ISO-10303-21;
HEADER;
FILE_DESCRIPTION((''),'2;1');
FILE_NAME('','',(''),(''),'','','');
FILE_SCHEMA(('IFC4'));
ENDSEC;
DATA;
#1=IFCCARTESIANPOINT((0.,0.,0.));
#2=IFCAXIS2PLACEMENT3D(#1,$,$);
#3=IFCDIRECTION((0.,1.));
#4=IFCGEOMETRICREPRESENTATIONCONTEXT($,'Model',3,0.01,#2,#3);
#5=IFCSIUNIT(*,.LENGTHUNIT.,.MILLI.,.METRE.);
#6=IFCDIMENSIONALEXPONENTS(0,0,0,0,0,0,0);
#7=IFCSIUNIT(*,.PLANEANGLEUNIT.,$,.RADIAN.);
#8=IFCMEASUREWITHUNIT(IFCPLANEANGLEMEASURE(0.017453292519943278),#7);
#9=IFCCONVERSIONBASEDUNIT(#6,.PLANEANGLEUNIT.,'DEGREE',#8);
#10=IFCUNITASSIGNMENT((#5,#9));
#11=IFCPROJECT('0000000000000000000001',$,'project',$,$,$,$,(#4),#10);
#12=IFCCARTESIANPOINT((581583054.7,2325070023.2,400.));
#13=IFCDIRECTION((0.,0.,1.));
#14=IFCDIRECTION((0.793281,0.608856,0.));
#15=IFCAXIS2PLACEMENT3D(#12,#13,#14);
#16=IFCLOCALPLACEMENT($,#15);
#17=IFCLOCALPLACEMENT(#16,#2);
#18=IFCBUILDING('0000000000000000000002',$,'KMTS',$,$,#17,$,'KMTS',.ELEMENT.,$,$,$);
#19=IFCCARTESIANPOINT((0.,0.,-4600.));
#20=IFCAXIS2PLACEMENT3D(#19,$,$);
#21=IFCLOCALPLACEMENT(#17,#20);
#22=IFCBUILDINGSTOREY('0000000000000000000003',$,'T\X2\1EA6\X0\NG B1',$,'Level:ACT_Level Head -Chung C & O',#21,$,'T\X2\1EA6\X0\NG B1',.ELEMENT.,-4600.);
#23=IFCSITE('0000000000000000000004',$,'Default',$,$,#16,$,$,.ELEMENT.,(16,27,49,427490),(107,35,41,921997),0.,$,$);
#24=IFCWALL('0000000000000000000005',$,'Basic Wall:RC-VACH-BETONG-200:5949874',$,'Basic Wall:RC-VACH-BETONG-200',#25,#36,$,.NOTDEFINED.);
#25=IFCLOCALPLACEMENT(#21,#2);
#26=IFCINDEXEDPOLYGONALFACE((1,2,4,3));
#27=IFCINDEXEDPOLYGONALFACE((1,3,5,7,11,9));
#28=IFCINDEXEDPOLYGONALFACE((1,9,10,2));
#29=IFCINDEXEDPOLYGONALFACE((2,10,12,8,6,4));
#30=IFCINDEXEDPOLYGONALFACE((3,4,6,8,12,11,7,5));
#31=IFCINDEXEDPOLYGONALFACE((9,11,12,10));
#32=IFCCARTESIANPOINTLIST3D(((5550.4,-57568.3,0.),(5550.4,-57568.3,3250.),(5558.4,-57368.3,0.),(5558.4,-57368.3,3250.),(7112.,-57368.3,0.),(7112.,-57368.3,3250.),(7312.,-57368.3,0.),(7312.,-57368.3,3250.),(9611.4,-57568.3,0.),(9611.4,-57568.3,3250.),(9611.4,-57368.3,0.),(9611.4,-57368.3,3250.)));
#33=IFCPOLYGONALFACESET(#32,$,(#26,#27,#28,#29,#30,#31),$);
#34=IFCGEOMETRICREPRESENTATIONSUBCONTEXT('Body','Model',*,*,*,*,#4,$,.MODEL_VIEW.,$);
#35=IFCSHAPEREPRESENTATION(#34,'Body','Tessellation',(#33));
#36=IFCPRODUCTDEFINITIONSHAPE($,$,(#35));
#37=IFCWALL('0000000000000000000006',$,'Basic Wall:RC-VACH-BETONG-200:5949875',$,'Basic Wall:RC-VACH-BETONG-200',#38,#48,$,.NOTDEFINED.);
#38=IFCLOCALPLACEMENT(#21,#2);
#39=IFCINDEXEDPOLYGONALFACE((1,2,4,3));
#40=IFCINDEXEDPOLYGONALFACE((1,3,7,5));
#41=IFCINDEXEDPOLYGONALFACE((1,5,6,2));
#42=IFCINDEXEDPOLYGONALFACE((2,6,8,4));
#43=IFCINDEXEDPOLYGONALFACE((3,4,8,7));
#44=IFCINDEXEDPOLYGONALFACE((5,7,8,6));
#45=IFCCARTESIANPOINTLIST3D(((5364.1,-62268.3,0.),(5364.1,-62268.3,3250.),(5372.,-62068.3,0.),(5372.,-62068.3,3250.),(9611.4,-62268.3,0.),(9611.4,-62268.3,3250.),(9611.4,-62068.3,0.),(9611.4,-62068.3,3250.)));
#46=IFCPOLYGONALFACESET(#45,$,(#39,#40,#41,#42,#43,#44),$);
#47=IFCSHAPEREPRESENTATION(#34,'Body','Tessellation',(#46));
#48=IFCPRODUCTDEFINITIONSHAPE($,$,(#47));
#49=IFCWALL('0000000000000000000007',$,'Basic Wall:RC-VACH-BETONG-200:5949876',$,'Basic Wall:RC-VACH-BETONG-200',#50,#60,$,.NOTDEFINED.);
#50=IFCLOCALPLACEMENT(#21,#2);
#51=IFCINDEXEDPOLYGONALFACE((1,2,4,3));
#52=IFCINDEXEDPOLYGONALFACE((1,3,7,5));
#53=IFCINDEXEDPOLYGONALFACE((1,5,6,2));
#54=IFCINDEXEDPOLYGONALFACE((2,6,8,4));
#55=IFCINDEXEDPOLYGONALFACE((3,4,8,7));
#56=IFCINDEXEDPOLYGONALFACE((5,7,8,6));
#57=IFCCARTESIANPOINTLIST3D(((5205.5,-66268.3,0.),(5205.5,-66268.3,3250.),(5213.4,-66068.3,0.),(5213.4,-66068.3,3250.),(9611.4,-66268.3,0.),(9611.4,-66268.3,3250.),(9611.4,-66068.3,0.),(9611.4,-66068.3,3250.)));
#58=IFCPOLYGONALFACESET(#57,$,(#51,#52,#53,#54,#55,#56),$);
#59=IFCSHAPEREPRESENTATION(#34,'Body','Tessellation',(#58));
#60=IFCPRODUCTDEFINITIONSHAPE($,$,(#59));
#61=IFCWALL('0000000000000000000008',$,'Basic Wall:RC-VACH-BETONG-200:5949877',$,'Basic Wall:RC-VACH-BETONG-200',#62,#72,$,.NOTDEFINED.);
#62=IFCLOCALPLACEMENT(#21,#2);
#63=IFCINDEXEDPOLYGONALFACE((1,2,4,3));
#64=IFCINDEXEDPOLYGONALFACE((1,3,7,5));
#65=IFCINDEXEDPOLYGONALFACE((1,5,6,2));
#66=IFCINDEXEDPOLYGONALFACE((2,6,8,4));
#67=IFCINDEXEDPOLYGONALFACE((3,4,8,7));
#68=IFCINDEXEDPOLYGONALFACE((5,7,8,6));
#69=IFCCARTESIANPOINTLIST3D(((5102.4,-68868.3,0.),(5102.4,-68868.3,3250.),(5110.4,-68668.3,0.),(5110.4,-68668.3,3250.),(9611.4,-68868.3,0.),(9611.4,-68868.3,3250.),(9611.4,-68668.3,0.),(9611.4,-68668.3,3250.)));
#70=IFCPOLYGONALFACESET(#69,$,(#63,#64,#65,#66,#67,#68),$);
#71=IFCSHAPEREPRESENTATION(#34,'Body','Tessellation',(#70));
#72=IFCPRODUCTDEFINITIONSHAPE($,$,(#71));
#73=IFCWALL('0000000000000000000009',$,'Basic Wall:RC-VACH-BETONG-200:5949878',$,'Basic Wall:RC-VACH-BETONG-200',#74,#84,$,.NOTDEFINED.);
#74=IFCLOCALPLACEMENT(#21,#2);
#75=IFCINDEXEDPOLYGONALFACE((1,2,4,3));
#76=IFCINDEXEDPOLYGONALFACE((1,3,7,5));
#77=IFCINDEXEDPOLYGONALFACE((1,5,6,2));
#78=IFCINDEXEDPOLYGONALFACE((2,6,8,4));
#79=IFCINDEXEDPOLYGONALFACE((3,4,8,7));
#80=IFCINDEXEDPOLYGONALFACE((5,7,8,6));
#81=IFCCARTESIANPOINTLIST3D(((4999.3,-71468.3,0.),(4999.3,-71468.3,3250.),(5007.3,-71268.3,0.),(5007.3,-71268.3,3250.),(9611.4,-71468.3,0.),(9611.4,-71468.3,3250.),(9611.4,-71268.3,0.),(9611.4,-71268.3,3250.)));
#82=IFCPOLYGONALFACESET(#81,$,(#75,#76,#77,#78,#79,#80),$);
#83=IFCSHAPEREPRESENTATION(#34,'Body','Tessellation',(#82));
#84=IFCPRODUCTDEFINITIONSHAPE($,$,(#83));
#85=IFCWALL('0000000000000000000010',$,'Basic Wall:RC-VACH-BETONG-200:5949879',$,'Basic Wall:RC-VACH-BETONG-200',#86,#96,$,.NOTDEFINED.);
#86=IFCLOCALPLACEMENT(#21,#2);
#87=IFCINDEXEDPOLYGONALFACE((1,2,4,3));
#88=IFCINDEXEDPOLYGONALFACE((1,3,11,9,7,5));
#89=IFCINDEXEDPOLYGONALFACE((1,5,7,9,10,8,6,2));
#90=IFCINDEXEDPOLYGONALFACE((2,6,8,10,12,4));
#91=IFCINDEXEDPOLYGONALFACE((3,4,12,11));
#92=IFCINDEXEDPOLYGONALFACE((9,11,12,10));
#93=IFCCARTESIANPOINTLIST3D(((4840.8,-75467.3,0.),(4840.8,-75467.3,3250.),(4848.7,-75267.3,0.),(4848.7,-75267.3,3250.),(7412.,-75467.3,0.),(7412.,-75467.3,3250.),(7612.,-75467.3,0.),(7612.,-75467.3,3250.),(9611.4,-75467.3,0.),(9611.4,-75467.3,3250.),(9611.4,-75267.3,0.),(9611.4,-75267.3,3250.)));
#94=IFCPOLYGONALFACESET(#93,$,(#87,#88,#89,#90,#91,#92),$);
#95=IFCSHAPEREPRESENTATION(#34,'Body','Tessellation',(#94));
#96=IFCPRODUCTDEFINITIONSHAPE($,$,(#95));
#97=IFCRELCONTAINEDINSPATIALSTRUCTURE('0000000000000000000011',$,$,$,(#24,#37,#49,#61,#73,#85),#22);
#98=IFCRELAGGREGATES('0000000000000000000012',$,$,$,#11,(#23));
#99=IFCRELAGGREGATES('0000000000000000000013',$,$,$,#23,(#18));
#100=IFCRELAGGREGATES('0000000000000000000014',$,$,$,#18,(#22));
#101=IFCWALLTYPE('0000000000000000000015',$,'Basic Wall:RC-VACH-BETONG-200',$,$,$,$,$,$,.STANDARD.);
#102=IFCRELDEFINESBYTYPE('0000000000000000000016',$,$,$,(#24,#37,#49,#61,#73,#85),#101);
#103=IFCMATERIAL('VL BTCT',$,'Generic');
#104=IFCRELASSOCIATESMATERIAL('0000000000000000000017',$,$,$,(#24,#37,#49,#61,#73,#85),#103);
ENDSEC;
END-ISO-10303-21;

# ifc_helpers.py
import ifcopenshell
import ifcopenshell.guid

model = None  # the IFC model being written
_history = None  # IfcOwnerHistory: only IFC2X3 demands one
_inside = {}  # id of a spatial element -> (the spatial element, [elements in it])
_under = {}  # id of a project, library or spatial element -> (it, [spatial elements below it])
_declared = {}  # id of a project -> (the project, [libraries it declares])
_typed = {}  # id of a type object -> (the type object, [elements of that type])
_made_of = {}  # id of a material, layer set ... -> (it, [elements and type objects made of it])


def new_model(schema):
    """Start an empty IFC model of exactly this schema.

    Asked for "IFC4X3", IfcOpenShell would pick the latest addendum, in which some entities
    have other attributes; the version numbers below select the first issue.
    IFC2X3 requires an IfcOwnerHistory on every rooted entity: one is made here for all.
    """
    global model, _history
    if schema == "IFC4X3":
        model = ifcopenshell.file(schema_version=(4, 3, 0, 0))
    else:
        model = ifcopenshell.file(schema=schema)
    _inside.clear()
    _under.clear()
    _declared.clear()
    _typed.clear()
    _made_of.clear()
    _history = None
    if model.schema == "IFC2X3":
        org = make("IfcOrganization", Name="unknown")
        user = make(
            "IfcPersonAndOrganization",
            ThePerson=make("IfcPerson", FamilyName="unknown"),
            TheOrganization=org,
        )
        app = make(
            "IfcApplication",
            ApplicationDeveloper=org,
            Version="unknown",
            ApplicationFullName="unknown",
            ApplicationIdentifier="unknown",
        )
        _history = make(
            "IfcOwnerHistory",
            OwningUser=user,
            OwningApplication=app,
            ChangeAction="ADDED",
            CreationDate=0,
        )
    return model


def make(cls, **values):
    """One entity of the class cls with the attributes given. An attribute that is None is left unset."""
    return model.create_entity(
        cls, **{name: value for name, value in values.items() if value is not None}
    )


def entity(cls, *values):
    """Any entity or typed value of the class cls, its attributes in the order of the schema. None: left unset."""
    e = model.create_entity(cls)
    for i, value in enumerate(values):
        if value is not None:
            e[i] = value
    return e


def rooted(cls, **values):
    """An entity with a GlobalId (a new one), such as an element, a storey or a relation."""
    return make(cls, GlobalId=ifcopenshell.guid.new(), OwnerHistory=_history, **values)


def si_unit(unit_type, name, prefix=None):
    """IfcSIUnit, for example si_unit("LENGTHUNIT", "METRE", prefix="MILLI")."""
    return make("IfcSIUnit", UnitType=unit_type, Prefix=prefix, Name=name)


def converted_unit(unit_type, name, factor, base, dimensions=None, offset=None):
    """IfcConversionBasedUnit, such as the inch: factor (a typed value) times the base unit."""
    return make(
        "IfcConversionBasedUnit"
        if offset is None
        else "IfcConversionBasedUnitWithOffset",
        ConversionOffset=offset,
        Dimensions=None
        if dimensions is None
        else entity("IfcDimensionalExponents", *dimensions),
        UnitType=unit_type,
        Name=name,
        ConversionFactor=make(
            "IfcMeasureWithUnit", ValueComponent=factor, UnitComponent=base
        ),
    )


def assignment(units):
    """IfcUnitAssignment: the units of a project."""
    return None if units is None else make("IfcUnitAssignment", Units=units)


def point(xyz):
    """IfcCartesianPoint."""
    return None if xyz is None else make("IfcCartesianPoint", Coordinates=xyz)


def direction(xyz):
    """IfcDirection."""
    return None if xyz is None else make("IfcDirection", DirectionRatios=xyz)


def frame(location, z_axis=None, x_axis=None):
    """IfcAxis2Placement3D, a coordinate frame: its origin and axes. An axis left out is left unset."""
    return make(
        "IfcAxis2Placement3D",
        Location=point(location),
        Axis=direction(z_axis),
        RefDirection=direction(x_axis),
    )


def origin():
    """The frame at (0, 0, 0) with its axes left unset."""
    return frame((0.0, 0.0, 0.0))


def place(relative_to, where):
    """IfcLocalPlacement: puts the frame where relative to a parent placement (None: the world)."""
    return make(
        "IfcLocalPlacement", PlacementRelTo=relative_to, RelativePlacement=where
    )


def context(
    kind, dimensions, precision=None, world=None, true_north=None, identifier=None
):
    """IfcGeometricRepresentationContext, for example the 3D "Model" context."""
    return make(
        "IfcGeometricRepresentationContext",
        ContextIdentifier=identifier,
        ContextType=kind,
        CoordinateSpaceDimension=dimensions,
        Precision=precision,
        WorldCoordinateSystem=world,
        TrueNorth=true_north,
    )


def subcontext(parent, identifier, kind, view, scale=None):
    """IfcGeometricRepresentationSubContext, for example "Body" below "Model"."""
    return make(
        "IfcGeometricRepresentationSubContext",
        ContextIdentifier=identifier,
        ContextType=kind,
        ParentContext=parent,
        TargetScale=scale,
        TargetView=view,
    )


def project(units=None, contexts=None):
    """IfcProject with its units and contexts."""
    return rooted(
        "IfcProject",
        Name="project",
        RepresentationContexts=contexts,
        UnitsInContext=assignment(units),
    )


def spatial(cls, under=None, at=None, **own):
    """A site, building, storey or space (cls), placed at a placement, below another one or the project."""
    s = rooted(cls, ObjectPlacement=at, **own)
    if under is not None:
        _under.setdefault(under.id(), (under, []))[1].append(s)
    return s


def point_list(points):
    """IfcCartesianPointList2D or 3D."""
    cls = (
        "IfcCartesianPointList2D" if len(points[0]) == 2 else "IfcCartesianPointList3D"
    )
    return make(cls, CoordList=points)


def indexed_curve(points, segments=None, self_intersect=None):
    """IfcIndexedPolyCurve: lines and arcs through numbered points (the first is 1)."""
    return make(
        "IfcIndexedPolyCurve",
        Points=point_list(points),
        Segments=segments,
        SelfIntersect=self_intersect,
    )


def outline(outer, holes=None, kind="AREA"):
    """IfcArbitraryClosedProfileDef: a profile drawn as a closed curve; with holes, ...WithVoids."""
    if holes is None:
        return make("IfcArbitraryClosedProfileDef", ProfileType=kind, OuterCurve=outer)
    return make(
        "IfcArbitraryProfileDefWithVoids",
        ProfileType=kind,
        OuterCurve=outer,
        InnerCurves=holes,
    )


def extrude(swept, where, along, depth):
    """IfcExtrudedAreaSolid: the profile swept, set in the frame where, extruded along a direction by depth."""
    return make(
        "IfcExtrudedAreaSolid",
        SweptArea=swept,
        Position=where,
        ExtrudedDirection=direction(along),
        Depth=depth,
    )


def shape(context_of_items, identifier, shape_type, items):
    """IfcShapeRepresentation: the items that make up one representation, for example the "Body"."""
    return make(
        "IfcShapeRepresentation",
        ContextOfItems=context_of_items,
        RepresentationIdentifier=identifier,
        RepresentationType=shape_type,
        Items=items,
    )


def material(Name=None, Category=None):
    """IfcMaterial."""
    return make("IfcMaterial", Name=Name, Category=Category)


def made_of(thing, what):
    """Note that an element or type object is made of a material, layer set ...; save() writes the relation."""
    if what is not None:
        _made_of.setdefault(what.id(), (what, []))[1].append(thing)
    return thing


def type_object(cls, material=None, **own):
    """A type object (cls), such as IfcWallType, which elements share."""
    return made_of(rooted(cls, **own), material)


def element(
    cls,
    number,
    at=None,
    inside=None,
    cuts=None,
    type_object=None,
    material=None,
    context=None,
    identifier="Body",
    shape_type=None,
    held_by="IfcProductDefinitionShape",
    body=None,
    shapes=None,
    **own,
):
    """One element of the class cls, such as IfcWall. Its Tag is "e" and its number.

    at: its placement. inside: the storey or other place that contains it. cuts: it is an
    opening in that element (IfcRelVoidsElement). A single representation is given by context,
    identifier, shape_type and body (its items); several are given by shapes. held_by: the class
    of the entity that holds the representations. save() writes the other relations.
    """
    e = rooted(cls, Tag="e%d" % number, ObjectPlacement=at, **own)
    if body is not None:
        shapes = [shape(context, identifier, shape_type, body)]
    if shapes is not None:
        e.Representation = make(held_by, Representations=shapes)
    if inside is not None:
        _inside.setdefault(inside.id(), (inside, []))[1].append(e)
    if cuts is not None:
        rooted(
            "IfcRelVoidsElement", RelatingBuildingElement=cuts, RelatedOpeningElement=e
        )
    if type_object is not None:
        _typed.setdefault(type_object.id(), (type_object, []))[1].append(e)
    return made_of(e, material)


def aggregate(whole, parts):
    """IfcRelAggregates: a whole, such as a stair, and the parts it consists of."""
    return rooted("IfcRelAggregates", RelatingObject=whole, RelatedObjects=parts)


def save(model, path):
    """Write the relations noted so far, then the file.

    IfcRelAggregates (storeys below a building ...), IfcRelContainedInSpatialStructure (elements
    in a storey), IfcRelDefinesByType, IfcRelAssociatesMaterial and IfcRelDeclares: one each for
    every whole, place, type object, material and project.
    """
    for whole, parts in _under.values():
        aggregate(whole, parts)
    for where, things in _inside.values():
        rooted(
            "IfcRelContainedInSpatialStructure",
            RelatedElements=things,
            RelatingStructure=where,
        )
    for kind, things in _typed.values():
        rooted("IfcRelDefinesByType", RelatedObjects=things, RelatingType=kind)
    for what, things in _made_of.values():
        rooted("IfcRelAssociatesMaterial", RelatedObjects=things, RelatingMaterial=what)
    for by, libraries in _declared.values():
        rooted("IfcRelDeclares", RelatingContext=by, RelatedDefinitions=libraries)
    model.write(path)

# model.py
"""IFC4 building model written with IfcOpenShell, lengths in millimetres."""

from ifc_helpers import new_model, entity, si_unit, converted_unit, direction, frame, origin, place, context, subcontext, project, spatial, indexed_curve, outline, extrude, material, type_object, element, save


model = new_model("IFC4")

# Units and contexts
model_context = context("Model", 3, precision=0.01, world=origin(), true_north=direction((0.0, 1.0)))
body_context = subcontext(model_context, "Body", "Model", "MODEL_VIEW")
ifc_project = project(units=[si_unit("LENGTHUNIT", "METRE", prefix="MILLI"), converted_unit("PLANEANGLEUNIT", "DEGREE", entity("IfcPlaneAngleMeasure", 0.017453292519943278), si_unit("PLANEANGLEUNIT", "RADIAN"), dimensions=[0, 0, 0, 0, 0, 0, 0])], contexts=[model_context])

# Site, building, storey
site_placement = place(None, frame((581583054.7, 2325070023.2, 400.0), z_axis=(0.0, 0.0, 1.0), x_axis=(0.793281, 0.608856, 0.0)))
site = spatial("IfcSite", under=ifc_project, at=site_placement, Name="Default", CompositionType="ELEMENT", RefLatitude=(16, 27, 49, 427490), RefLongitude=(107, 35, 41, 921997), RefElevation=0.0)
building_placement = place(site_placement, origin())
building = spatial("IfcBuilding", under=site, at=building_placement, Name="KMTS", LongName="KMTS", CompositionType="ELEMENT")
storey_placement = place(building_placement, frame((0.0, 0.0, -4600.0)))
storey = spatial("IfcBuildingStorey", under=building, at=storey_placement, Name="TẦNG B1", ObjectType="Level:ACT_Level Head -Chung C & O", LongName="TẦNG B1", CompositionType="ELEMENT", Elevation=-4600.0)

# Shared definitions
ifc_material = material(Name="VL BTCT", Category="Generic")

# Walls
wall_type_1 = type_object("IfcWallType", Name="Basic Wall:RC-VACH-BETONG-200", PredefinedType="STANDARD")
wall_1_placement = place(storey_placement, frame((9611.4, -57468.3, 0.0), z_axis=(0.0, 0.0, 1.0), x_axis=(-1.0, 0.0, 0.0)))
element("IfcWall", 1, at=wall_1_placement, inside=storey, type_object=wall_type_1, material=ifc_material, Name="Basic Wall:RC-VACH-BETONG-200:5949874", ObjectType="Basic Wall:RC-VACH-BETONG-200", PredefinedType="NOTDEFINED", context=body_context, shape_type="SweptSolid", body=[
    extrude(outline(indexed_curve([(4053.0, -100.0), (4061.0, 100.0), (0.0, 100.0), (0.0, -100.0), (2299.4, -100.0), (2499.4, -100.0), (4053.0, -100.0)], self_intersect=False)), origin(), (0.0, 0.0, 1.0), 3250.0),
])
wall_2_placement = place(storey_placement, frame((9611.4, -62168.3, 0.0), z_axis=(0.0, 0.0, 1.0), x_axis=(-1.0, 0.0, 0.0)))
element("IfcWall", 2, at=wall_2_placement, inside=storey, type_object=wall_type_1, material=ifc_material, Name="Basic Wall:RC-VACH-BETONG-200:5949875", ObjectType="Basic Wall:RC-VACH-BETONG-200", PredefinedType="NOTDEFINED", context=body_context, shape_type="SweptSolid", body=[
    extrude(outline(indexed_curve([(4239.4, -100.0), (4247.3, 100.0), (0.0, 100.0), (0.0, -100.0), (4239.4, -100.0)], self_intersect=False)), origin(), (0.0, 0.0, 1.0), 3250.0),
])
wall_3_placement = place(storey_placement, frame((9611.4, -66168.3, 0.0), z_axis=(0.0, 0.0, 1.0), x_axis=(-1.0, 0.0, 0.0)))
element("IfcWall", 3, at=wall_3_placement, inside=storey, type_object=wall_type_1, material=ifc_material, Name="Basic Wall:RC-VACH-BETONG-200:5949876", ObjectType="Basic Wall:RC-VACH-BETONG-200", PredefinedType="NOTDEFINED", context=body_context, shape_type="SweptSolid", body=[
    extrude(outline(indexed_curve([(4398.0, -100.0), (4405.9, 100.0), (0.0, 100.0), (0.0, -100.0), (4398.0, -100.0)], self_intersect=False)), origin(), (0.0, 0.0, 1.0), 3250.0),
])
wall_4_placement = place(storey_placement, frame((9611.4, -68768.3, 0.0), z_axis=(0.0, 0.0, 1.0), x_axis=(-1.0, 0.0, 0.0)))
element("IfcWall", 4, at=wall_4_placement, inside=storey, type_object=wall_type_1, material=ifc_material, Name="Basic Wall:RC-VACH-BETONG-200:5949877", ObjectType="Basic Wall:RC-VACH-BETONG-200", PredefinedType="NOTDEFINED", context=body_context, shape_type="SweptSolid", body=[
    extrude(outline(indexed_curve([(4501.0, -100.0), (4509.0, 100.0), (0.0, 100.0), (0.0, -100.0), (4501.0, -100.0)], self_intersect=False)), origin(), (0.0, 0.0, 1.0), 3250.0),
])
wall_5_placement = place(storey_placement, frame((9611.4, -71368.3, 0.0), z_axis=(0.0, 0.0, 1.0), x_axis=(-1.0, 0.0, 0.0)))
element("IfcWall", 5, at=wall_5_placement, inside=storey, type_object=wall_type_1, material=ifc_material, Name="Basic Wall:RC-VACH-BETONG-200:5949878", ObjectType="Basic Wall:RC-VACH-BETONG-200", PredefinedType="NOTDEFINED", context=body_context, shape_type="SweptSolid", body=[
    extrude(outline(indexed_curve([(4604.1, -100.0), (4612.0, 100.0), (0.0, 100.0), (0.0, -100.0), (4604.1, -100.0)], self_intersect=False)), origin(), (0.0, 0.0, 1.0), 3250.0),
])
wall_6_placement = place(storey_placement, frame((9611.4, -75367.3, 0.0), z_axis=(0.0, 0.0, 1.0), x_axis=(-1.0, 0.0, 0.0)))
element("IfcWall", 6, at=wall_6_placement, inside=storey, type_object=wall_type_1, material=ifc_material, Name="Basic Wall:RC-VACH-BETONG-200:5949879", ObjectType="Basic Wall:RC-VACH-BETONG-200", PredefinedType="NOTDEFINED", context=body_context, shape_type="SweptSolid", body=[
    extrude(outline(indexed_curve([(4762.7, -100.0), (4770.6, 100.0), (2199.4, 100.0), (1999.4, 100.0), (0.0, 100.0), (0.0, -100.0), (4762.7, -100.0)], self_intersect=False)), origin(), (0.0, 0.0, 1.0), 3250.0),
])

save(model, "model.ifc")
